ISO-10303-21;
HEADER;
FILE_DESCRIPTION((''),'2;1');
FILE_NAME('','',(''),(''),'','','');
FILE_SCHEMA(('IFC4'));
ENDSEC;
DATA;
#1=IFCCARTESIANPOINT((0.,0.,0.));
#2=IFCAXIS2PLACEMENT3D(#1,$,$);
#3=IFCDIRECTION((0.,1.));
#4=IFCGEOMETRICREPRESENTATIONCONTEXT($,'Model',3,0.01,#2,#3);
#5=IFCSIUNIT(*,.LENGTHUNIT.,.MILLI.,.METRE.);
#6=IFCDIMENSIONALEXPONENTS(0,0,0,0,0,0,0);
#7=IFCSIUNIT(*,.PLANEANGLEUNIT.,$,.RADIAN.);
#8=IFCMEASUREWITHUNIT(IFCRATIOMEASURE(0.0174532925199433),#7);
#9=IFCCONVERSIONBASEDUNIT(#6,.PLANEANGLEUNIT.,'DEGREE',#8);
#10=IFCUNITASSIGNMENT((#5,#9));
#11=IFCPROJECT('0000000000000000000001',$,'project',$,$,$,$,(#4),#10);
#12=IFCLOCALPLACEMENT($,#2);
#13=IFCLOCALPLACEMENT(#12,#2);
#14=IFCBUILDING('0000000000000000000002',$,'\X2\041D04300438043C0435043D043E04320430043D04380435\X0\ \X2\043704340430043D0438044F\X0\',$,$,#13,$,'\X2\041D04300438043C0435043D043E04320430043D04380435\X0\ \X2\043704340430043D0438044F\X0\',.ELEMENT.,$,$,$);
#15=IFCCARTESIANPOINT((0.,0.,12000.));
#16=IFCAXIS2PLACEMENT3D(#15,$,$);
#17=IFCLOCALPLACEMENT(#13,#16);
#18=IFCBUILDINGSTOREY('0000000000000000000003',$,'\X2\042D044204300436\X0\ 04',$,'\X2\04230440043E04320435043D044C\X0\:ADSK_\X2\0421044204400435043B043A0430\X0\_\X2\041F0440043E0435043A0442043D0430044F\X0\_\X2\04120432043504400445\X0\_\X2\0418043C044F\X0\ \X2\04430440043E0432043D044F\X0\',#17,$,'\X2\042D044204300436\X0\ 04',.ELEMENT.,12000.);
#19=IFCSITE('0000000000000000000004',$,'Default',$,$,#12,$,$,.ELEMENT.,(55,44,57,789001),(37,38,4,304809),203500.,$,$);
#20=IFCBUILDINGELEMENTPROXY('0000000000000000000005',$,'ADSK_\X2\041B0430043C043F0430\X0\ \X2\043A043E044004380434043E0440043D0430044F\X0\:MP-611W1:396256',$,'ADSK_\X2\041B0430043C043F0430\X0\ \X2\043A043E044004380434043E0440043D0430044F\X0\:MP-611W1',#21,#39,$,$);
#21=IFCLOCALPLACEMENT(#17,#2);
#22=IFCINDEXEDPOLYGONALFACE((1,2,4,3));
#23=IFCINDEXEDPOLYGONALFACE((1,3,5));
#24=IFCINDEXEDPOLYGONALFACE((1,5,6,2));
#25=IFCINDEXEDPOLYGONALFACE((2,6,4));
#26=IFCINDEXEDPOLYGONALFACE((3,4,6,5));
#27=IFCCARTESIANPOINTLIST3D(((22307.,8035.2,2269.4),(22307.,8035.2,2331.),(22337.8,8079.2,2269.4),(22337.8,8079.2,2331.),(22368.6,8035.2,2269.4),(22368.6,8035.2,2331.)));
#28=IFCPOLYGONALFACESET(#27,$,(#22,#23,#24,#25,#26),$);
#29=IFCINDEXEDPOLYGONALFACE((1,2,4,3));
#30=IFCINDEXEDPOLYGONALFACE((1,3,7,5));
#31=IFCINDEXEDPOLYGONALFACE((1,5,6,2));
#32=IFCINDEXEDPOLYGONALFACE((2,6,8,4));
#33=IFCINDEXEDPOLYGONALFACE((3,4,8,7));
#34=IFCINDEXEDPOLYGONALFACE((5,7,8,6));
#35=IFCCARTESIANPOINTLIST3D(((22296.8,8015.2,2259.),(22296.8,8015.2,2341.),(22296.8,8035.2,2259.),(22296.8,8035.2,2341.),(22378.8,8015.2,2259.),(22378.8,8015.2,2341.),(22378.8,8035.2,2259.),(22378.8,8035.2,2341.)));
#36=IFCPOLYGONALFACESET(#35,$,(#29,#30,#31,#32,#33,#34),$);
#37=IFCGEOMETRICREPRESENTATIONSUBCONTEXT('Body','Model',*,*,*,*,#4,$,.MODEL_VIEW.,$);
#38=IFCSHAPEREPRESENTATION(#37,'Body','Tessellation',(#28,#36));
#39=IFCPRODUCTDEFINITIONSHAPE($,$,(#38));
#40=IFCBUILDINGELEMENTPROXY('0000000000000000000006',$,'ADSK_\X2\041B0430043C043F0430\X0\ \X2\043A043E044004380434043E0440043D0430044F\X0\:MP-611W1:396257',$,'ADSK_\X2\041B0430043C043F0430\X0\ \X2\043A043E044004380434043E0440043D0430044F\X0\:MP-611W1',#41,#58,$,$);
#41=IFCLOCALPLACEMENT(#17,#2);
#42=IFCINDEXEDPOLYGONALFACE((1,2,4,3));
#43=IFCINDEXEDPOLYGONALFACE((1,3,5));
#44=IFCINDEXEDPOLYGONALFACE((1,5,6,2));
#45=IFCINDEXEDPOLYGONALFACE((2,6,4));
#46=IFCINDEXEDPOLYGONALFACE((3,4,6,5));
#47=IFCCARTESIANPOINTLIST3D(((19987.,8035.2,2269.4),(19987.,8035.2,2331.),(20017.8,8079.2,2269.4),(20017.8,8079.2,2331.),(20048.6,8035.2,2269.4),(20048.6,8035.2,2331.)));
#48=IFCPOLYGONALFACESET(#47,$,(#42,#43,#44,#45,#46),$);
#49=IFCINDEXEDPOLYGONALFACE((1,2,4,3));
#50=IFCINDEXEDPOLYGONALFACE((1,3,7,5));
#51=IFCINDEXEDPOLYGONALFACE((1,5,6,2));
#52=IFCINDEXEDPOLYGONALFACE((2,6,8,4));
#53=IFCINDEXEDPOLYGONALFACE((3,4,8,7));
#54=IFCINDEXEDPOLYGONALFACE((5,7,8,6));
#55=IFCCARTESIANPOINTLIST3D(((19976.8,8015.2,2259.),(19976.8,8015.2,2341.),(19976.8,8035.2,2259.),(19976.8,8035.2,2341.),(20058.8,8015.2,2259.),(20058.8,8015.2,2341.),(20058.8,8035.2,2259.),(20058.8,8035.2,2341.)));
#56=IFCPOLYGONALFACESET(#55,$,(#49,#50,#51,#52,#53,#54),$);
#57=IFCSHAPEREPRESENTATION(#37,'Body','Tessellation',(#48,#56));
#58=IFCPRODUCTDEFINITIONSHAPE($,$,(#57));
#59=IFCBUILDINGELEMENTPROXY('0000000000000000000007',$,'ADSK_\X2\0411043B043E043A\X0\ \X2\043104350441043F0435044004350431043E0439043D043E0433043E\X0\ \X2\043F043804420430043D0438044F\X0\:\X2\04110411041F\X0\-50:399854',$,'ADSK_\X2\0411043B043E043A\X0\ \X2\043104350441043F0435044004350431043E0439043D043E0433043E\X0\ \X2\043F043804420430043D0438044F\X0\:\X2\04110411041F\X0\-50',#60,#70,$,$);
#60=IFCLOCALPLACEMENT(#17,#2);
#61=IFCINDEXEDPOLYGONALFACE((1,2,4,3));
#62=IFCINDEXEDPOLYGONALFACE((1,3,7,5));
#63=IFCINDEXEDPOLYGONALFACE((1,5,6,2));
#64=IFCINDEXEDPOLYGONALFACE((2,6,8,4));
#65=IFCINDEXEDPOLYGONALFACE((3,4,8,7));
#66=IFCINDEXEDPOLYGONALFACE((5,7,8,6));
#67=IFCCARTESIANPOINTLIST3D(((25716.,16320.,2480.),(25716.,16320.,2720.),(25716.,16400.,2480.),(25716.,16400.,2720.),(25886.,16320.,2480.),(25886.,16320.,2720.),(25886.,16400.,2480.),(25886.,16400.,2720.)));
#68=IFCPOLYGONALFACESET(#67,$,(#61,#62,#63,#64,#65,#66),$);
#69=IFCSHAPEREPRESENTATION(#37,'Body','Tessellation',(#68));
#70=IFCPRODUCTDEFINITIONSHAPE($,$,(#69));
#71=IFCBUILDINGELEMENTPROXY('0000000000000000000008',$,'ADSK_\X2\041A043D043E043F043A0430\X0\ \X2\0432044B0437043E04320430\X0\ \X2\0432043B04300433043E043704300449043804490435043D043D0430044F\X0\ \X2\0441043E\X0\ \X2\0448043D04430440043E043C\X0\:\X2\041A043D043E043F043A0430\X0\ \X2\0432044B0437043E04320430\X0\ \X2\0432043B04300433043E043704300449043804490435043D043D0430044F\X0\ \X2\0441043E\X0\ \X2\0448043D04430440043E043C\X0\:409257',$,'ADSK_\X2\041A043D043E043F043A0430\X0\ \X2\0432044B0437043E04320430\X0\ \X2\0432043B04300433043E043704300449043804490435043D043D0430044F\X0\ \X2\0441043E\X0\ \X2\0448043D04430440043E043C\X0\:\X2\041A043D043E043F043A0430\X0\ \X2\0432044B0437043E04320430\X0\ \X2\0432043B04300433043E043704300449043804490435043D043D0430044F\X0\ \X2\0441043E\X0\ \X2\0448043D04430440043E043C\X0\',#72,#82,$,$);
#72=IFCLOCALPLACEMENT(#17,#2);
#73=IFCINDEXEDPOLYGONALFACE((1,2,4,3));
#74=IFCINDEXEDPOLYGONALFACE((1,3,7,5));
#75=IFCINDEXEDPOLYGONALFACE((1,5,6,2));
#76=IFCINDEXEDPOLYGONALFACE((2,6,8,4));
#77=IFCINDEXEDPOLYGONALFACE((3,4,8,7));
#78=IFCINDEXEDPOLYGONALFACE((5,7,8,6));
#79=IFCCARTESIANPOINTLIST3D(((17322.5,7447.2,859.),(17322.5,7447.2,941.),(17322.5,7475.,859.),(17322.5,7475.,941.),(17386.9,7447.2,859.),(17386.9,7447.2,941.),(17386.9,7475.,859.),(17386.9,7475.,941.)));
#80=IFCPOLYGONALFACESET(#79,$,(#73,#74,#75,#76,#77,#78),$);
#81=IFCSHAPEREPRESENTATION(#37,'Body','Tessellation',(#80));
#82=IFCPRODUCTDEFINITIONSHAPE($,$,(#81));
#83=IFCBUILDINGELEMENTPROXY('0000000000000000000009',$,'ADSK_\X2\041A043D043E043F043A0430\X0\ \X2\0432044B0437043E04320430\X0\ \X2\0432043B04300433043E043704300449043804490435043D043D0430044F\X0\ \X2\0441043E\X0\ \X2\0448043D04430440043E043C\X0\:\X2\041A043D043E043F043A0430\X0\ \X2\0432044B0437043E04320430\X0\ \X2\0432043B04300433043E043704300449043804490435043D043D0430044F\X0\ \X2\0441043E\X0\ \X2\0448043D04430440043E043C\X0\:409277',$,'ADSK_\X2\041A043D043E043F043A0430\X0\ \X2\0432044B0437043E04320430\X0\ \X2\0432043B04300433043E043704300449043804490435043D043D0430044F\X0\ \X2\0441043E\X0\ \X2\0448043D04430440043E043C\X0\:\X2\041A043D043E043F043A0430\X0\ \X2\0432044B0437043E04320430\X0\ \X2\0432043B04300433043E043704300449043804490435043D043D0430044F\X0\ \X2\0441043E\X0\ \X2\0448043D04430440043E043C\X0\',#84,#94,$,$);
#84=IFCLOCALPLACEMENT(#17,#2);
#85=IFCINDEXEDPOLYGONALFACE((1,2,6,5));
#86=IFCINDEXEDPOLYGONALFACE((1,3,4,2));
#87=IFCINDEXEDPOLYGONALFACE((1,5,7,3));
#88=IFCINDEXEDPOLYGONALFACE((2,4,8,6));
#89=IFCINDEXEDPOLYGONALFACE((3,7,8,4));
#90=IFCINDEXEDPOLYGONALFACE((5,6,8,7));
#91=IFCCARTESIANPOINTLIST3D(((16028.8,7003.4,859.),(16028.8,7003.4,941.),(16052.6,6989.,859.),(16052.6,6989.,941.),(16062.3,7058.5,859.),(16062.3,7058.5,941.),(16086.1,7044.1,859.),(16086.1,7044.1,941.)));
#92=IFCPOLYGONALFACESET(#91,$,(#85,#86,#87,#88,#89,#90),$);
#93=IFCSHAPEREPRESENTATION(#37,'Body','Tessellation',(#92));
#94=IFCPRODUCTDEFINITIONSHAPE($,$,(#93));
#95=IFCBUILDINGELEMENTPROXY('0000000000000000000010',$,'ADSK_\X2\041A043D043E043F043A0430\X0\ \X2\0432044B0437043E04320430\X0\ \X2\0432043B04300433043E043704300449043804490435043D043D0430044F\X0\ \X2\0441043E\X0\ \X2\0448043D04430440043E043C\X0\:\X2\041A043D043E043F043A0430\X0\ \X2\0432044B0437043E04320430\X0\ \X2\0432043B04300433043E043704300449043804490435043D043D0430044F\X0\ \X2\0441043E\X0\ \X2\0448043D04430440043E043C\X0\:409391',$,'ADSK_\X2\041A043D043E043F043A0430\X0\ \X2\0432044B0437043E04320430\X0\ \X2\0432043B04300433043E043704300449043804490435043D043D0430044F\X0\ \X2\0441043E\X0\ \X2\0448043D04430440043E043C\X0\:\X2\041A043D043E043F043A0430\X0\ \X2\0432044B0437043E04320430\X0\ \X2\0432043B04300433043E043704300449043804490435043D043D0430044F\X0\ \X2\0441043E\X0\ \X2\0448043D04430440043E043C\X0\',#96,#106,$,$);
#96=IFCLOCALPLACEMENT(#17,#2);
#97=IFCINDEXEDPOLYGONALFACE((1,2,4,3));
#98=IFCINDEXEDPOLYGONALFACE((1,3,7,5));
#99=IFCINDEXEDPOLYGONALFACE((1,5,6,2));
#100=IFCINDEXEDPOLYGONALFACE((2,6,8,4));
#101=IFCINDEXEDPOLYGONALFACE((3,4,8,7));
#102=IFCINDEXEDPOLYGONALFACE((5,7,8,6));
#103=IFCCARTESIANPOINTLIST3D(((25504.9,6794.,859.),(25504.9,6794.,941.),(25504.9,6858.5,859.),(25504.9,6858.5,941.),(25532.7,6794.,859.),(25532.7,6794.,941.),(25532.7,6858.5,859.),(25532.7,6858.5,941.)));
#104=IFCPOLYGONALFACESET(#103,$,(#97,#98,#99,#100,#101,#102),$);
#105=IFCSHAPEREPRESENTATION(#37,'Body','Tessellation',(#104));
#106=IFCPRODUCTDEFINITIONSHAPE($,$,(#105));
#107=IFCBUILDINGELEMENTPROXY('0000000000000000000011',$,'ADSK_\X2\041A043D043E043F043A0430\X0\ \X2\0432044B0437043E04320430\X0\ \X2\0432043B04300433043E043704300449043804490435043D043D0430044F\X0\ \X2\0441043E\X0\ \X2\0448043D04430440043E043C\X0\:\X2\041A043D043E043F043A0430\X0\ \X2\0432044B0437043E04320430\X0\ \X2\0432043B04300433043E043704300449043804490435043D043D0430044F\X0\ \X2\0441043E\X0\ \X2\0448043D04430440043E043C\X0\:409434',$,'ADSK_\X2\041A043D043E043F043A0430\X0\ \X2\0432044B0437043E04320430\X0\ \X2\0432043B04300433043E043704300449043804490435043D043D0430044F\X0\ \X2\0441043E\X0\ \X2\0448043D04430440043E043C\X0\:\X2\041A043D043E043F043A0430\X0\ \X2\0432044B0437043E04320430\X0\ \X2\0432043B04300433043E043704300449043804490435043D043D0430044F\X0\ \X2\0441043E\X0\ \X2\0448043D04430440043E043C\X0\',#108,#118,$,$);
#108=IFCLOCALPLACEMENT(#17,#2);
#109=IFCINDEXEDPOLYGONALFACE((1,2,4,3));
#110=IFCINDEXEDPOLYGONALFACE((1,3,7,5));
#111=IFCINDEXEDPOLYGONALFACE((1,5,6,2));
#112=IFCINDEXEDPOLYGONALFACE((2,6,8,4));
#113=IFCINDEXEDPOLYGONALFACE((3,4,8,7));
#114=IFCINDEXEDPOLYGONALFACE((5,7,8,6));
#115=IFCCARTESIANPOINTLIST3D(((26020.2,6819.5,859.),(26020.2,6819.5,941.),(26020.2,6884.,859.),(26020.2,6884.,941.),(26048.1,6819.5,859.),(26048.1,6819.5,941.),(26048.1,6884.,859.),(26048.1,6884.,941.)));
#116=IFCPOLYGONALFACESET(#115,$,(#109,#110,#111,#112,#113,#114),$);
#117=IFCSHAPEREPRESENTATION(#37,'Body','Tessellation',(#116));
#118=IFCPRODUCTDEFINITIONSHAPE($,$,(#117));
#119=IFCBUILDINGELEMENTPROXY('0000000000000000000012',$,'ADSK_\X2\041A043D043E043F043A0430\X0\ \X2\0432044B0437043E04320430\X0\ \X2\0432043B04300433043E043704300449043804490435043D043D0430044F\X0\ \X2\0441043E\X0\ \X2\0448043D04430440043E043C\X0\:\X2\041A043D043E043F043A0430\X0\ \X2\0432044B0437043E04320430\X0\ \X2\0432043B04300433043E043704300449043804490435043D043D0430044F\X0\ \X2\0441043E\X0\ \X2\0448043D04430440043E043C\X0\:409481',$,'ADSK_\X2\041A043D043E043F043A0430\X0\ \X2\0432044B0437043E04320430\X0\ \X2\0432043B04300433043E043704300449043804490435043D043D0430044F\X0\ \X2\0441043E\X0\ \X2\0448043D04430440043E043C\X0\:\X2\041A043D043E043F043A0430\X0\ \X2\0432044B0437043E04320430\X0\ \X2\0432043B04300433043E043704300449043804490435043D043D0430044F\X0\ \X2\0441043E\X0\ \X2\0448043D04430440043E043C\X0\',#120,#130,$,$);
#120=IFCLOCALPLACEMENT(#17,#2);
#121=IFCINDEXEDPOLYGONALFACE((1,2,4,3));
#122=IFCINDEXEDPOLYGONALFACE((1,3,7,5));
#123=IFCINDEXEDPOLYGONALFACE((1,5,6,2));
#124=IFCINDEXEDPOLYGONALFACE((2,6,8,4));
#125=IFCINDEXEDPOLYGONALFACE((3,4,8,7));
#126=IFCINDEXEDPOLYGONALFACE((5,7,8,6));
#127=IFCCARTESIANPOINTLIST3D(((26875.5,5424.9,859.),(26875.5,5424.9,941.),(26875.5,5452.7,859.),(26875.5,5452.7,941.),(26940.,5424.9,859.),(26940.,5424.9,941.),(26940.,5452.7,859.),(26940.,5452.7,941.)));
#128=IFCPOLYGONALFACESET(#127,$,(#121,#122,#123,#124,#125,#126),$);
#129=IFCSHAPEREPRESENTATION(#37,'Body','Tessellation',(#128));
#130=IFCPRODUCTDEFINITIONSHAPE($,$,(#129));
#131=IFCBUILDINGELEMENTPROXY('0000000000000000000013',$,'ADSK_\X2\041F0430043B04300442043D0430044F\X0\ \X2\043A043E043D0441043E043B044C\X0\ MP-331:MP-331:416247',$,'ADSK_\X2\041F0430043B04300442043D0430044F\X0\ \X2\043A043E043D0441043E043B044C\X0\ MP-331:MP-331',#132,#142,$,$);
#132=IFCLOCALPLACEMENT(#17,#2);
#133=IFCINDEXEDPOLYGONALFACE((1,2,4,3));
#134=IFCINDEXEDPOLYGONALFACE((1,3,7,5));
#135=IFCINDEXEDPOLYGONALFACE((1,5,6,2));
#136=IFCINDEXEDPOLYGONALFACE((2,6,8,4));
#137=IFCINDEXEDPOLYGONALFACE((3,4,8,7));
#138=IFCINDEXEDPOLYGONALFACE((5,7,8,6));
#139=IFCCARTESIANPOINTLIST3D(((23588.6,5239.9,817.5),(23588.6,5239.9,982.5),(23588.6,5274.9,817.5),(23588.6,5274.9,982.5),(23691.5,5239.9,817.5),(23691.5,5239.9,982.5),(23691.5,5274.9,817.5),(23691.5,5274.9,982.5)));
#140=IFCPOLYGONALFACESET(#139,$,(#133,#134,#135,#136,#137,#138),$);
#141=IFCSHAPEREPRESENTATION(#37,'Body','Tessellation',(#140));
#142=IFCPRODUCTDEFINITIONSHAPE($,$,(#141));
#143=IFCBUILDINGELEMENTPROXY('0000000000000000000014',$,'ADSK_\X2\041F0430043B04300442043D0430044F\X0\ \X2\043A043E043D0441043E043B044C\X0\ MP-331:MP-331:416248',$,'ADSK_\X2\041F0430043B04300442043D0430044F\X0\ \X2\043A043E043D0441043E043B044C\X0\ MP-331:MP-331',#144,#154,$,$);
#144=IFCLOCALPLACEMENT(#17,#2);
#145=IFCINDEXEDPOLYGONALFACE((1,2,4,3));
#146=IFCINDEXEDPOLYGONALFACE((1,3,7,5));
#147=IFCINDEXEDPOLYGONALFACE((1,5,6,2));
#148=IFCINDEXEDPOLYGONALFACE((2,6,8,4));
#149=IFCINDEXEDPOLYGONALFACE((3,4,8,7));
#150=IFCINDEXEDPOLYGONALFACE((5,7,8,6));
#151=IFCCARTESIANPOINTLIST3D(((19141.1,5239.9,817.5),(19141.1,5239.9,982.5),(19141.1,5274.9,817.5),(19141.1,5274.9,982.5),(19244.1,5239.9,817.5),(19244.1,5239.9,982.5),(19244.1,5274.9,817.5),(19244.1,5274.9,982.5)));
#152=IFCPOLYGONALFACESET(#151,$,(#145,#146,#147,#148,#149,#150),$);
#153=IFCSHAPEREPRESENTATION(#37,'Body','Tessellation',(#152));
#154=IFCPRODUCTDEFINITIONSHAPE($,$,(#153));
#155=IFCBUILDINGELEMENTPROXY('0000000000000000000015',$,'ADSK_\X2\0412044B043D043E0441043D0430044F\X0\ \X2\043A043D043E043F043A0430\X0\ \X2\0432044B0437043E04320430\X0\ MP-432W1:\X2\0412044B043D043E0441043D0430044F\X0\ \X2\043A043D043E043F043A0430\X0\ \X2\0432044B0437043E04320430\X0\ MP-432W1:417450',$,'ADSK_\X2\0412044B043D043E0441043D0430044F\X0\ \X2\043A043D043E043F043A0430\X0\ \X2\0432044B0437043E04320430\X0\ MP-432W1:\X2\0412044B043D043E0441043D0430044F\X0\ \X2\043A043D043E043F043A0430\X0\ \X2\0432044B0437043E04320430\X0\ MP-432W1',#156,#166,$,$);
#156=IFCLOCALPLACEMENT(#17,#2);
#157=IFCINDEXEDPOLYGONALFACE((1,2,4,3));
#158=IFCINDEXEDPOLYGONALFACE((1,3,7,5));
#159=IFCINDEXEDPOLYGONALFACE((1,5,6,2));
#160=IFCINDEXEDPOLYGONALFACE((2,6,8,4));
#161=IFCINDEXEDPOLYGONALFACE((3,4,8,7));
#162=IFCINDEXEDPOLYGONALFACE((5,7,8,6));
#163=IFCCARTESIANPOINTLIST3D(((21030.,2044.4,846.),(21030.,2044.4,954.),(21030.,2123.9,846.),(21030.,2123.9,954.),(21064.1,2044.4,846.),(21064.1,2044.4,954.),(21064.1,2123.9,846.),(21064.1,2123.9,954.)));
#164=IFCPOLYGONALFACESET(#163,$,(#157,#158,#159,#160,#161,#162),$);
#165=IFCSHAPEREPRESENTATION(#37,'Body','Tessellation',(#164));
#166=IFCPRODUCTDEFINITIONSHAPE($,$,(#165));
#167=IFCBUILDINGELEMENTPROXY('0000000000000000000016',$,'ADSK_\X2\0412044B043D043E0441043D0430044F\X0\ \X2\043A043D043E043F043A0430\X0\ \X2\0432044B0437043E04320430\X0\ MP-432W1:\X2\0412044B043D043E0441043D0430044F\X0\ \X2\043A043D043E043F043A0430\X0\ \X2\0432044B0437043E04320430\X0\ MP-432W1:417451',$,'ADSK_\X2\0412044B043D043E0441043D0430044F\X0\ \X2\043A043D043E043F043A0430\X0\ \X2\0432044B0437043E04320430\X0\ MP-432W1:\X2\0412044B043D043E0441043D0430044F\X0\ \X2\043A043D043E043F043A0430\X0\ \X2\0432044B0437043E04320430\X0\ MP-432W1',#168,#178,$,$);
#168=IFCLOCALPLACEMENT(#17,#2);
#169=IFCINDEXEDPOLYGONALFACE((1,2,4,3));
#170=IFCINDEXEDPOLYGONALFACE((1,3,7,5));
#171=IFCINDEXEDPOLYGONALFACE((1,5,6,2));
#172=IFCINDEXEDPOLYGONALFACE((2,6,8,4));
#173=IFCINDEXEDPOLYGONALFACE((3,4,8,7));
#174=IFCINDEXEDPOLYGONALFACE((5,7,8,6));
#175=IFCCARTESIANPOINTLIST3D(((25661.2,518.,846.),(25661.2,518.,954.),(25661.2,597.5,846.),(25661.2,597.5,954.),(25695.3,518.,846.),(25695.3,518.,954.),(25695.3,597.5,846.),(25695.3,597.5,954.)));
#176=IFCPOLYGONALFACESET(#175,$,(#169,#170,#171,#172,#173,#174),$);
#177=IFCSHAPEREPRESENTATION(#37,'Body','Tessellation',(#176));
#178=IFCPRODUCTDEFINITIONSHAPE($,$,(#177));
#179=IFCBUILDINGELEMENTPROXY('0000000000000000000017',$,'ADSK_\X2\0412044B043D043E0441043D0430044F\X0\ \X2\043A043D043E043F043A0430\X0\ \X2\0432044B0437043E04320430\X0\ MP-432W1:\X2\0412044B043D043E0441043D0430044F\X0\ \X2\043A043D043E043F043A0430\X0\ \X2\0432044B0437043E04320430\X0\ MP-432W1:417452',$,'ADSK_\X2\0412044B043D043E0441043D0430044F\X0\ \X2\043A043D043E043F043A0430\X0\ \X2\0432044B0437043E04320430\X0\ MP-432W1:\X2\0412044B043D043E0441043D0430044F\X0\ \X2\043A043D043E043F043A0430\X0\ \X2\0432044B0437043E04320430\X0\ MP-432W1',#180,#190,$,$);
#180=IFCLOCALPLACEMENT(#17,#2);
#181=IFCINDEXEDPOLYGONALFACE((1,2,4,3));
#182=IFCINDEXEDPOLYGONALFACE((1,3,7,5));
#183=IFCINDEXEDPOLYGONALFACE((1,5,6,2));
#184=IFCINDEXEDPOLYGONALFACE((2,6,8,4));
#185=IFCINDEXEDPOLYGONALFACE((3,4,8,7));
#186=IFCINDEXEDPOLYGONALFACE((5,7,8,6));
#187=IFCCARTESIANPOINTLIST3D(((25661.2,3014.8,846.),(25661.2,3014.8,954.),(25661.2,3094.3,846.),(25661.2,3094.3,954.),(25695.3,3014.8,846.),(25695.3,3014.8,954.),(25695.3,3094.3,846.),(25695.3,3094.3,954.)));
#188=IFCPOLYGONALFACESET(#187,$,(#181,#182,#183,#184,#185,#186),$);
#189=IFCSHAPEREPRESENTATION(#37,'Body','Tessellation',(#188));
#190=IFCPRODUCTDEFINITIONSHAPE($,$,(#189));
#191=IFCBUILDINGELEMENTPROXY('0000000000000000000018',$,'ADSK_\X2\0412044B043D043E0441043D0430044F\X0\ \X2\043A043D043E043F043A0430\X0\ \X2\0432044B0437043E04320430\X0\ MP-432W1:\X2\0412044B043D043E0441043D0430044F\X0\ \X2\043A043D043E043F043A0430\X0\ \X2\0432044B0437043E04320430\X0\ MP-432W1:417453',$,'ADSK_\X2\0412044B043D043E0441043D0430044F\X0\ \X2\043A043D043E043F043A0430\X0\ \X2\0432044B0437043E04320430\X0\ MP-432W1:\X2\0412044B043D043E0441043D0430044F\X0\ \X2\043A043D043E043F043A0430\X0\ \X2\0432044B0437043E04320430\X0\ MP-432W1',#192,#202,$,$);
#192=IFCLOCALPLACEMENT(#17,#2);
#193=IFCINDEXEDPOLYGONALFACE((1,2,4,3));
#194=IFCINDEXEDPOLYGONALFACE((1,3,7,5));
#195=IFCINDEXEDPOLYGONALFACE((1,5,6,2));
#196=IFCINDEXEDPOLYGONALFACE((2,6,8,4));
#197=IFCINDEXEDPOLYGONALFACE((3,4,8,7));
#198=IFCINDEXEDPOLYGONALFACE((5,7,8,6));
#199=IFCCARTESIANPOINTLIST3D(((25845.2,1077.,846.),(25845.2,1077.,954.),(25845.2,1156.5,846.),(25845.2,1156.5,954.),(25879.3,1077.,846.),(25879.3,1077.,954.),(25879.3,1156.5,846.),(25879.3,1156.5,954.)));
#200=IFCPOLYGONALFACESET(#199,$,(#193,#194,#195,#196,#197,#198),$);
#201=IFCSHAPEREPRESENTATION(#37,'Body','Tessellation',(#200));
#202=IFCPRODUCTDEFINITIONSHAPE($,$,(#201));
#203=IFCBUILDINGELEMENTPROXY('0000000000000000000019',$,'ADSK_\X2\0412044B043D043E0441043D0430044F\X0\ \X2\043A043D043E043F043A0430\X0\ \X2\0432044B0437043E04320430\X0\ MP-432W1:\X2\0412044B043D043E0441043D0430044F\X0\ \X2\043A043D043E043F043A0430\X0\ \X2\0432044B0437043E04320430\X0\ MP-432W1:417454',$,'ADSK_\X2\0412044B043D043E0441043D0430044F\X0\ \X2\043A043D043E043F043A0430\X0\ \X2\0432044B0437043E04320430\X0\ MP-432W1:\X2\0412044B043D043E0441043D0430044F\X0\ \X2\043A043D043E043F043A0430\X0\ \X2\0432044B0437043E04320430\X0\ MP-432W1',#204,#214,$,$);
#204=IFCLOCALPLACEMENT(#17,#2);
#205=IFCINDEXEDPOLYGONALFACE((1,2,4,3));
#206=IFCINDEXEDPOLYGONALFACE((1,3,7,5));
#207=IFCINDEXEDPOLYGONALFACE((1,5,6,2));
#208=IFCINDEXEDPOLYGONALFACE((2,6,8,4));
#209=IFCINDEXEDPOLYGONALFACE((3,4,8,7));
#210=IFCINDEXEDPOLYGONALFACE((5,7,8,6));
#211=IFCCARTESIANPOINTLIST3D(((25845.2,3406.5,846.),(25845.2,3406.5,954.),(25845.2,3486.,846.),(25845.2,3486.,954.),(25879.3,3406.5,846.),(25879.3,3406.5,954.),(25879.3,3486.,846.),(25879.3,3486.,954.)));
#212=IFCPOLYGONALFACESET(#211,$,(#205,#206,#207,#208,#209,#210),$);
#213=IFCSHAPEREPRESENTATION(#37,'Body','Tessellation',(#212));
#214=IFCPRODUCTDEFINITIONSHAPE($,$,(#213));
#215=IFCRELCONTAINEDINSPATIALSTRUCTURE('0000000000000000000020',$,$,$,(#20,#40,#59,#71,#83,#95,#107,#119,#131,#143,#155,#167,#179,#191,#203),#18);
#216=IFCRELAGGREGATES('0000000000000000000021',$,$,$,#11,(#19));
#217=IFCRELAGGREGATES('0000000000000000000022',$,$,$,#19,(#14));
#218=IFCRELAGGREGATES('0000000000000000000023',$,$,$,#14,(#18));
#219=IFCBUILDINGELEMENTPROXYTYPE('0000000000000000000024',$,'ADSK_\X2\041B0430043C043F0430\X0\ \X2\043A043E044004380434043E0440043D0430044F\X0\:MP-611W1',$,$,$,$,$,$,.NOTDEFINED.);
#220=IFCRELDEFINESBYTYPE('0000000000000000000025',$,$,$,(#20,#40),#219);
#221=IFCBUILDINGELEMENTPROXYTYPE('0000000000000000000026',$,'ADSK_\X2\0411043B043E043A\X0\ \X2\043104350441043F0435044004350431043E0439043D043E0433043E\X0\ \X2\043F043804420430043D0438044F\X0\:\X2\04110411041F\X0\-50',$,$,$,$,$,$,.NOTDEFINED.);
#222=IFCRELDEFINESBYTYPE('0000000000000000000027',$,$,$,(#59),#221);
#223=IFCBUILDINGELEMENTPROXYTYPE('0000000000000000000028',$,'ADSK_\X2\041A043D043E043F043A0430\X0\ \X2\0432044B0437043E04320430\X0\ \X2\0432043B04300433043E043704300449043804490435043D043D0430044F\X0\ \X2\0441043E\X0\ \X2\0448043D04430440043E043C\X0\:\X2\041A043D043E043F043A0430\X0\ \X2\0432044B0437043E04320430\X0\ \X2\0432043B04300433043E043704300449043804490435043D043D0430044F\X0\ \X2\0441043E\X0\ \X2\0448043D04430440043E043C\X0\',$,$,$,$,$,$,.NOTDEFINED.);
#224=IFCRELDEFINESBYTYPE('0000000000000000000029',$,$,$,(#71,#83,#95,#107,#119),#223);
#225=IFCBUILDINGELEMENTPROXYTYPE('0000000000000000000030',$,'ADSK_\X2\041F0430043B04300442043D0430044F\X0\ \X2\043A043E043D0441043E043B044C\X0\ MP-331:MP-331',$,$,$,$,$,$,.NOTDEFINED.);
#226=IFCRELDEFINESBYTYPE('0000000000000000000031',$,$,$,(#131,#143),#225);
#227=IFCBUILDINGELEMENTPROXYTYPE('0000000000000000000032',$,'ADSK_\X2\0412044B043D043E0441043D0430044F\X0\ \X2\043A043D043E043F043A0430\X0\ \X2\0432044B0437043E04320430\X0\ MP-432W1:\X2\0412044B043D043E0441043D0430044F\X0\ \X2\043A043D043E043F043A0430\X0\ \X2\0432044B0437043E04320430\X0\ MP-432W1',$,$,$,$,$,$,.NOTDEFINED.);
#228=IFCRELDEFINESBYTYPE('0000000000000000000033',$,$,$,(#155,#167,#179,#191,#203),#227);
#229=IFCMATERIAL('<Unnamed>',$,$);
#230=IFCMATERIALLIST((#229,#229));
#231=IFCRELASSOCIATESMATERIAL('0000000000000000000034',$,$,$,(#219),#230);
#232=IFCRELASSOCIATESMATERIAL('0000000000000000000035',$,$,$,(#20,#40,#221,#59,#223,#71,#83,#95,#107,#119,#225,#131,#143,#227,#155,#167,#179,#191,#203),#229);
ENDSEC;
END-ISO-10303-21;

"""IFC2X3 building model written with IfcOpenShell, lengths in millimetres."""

from ifc_helpers import new_model, entity, si_unit, converted_unit, direction, frame, origin, origin_2d_with_axis, place, context, subcontext, project, spatial, polyline, rectangle, outline, extrude, source, transform, mapped, material, material_list, type_object, type_shapes, element, save


model = new_model("IFC2X3")

# Units and contexts
model_context = context("Model", 3, precision=0.01, world=origin(), true_north=direction((0.0, 1.0)))
body_context = subcontext(model_context, "Body", "Model", "MODEL_VIEW")
ifc_project = project(units=[si_unit("LENGTHUNIT", "METRE", prefix="MILLI"), converted_unit("PLANEANGLEUNIT", "DEGREE", entity("IfcRatioMeasure", 0.0174532925199433), si_unit("PLANEANGLEUNIT", "RADIAN"), dimensions=[0, 0, 0, 0, 0, 0, 0])], contexts=[model_context])

# Site, building, storey
site_placement = place(None, origin())
site = spatial("IfcSite", under=ifc_project, at=site_placement, Name="Default", CompositionType="ELEMENT", RefLatitude=(55, 44, 57, 789001), RefLongitude=(37, 38, 4, 304809), RefElevation=203500.0)
building_placement = place(site_placement, origin())
building = spatial("IfcBuilding", under=site, at=building_placement, Name="Наименование здания", LongName="Наименование здания", CompositionType="ELEMENT")
storey_placement = place(building_placement, frame((0.0, 0.0, 12000.0)))
storey = spatial("IfcBuildingStorey", under=building, at=storey_placement, Name="Этаж 04", ObjectType="Уровень:ADSK_Стрелка_Проектная_Вверх_Имя уровня", LongName="Этаж 04", CompositionType="ELEMENT", Elevation=12000.0)

# Building element proxies
ifc_material_1 = material(Name="<Unnamed>")
ifc_material_list_1 = material_list([ifc_material_1, ifc_material_1])
building_element_proxy_type_1 = type_object("IfcBuildingElementProxyType", Name="ADSK_Лампа коридорная:MP-611W1", PredefinedType="NOTDEFINED", material=ifc_material_list_1)
shared_shape_1 = source(origin(), body_context, "Body", "SweptSolid", [
    extrude(outline(polyline([(-30.8, -14.7), (30.8, -14.7), (0.0, 29.3), (-30.8, -14.7)])), frame((0.0, -2.7, -30.6), z_axis=(0.0, 0.0, 1.0), x_axis=(-1.0, 0.0, 0.0)), (0.0, 0.0, 1.0), 61.6),
    extrude(rectangle(XDim=82.0, YDim=20.0, at=origin_2d_with_axis()), frame((0.0, 22.0, -41.0), z_axis=(0.0, 0.0, 1.0), x_axis=(-1.0, 0.0, 0.0)), (0.0, 0.0, 1.0), 82.0),
])
type_shapes(building_element_proxy_type_1, [shared_shape_1])
for number, where, z_axis, x_axis, name in (
    (1, (22337.8, 8047.1, 2300.0), (0.0, 0.0, 1.0), (-1.0, 0.0, 0.0), "ADSK_Лампа коридорная:MP-611W1:396256"),
    (2, (20017.8, 8047.1, 2300.0), (0.0, 0.0, 1.0), (-1.0, 0.0, 0.0), "ADSK_Лампа коридорная:MP-611W1:396257"),
):
    element("IfcBuildingElementProxy", number, at=place(storey_placement, frame(where, z_axis=z_axis, x_axis=x_axis)), inside=storey, type_object=building_element_proxy_type_1, material=ifc_material_1, Name=name, ObjectType="ADSK_Лампа коридорная:MP-611W1", context=body_context, shape_type="MappedRepresentation", body=[
        mapped(shared_shape_1, transform((0.0, 0.0, 0.0), scale=1.0)),
    ])
building_element_proxy_type_2 = type_object("IfcBuildingElementProxyType", Name="ADSK_Блок бесперебойного питания:ББП-50", PredefinedType="NOTDEFINED", material=ifc_material_1)
shared_shape_2 = source(origin(), body_context, "Body", "SweptSolid", [
    extrude(rectangle(XDim=170.0, YDim=80.0, at=origin_2d_with_axis()), frame((0.0, -8.0, -120.0), z_axis=(0.0, 0.0, 1.0), x_axis=(-1.0, 0.0, 0.0)), (0.0, 0.0, 1.0), 240.0),
])
type_shapes(building_element_proxy_type_2, [shared_shape_2])
proxy_1_placement = place(storey_placement, frame((25801.0, 16368.0, 2600.0)))
element("IfcBuildingElementProxy", 3, at=proxy_1_placement, inside=storey, type_object=building_element_proxy_type_2, material=ifc_material_1, Name="ADSK_Блок бесперебойного питания:ББП-50:399854", ObjectType="ADSK_Блок бесперебойного питания:ББП-50", context=body_context, shape_type="MappedRepresentation", body=[
    mapped(shared_shape_2, transform((0.0, 0.0, 0.0), scale=1.0)),
])
building_element_proxy_type_3 = type_object("IfcBuildingElementProxyType", Name="ADSK_Кнопка вызова влагозащищенная со шнуром:Кнопка вызова влагозащищенная со шнуром", PredefinedType="NOTDEFINED", material=ifc_material_1)
shared_shape_3 = source(origin(), body_context, "Body", "SweptSolid", [
    extrude(rectangle(XDim=64.5, YDim=27.8, at=origin_2d_with_axis()), frame((32.2, 13.9, 0.0), z_axis=(0.0, 0.0, 1.0), x_axis=(-1.0, 0.0, 0.0)), (0.0, 0.0, 1.0), 82.0),
])
type_shapes(building_element_proxy_type_3, [shared_shape_3])
proxy_2_placement = place(storey_placement, frame((17322.5, 7447.2, 859.0)))
element("IfcBuildingElementProxy", 4, at=proxy_2_placement, inside=storey, type_object=building_element_proxy_type_3, material=ifc_material_1, Name="ADSK_Кнопка вызова влагозащищенная со шнуром:Кнопка вызова влагозащищенная со шнуром:409257", ObjectType="ADSK_Кнопка вызова влагозащищенная со шнуром:Кнопка вызова влагозащищенная со шнуром", context=body_context, shape_type="MappedRepresentation", body=[
    mapped(shared_shape_3, transform((0.0, 0.0, 0.0), scale=1.0)),
])
for number, where, z_axis, x_axis, name in (
    (5, (16052.6, 6989.0, 859.0), (0.0, 0.0, 1.0), (0.519535, 0.854449, 0.0), "ADSK_Кнопка вызова влагозащищенная со шнуром:Кнопка вызова влагозащищенная со шнуром:409277"),
    (6, (25504.9, 6858.5, 859.0), (0.0, 0.0, 1.0), (0.0, -1.0, 0.0), "ADSK_Кнопка вызова влагозащищенная со шнуром:Кнопка вызова влагозащищенная со шнуром:409391"),
    (7, (26048.1, 6819.5, 859.0), (0.0, 0.0, 1.0), (0.0, 1.0, 0.0), "ADSK_Кнопка вызова влагозащищенная со шнуром:Кнопка вызова влагозащищенная со шнуром:409434"),
    (8, (26940.0, 5452.8, 859.0), (0.0, 0.0, 1.0), (-1.0, 0.0, 0.0), "ADSK_Кнопка вызова влагозащищенная со шнуром:Кнопка вызова влагозащищенная со шнуром:409481"),
):
    element("IfcBuildingElementProxy", number, at=place(storey_placement, frame(where, z_axis=z_axis, x_axis=x_axis)), inside=storey, type_object=building_element_proxy_type_3, material=ifc_material_1, Name=name, ObjectType="ADSK_Кнопка вызова влагозащищенная со шнуром:Кнопка вызова влагозащищенная со шнуром", context=body_context, shape_type="MappedRepresentation", body=[
        mapped(shared_shape_3, transform((0.0, 0.0, 0.0), scale=1.0)),
    ])
building_element_proxy_type_4 = type_object("IfcBuildingElementProxyType", Name="ADSK_Палатная консоль MP-331:MP-331", PredefinedType="NOTDEFINED", material=ifc_material_1)
shared_shape_4 = source(origin(), body_context, "Body", "SweptSolid", [
    extrude(rectangle(XDim=103.0, YDim=35.0, at=origin_2d_with_axis()), frame((0.0, 14.5, -82.5), z_axis=(0.0, 0.0, 1.0), x_axis=(-1.0, 0.0, 0.0)), (0.0, 0.0, 1.0), 165.0),
])
type_shapes(building_element_proxy_type_4, [shared_shape_4])
for number, where, name in (
    (9, (23640.0, 5242.9, 900.0), "ADSK_Палатная консоль MP-331:MP-331:416247"),
    (10, (19192.6, 5242.9, 900.0), "ADSK_Палатная консоль MP-331:MP-331:416248"),
):
    element("IfcBuildingElementProxy", number, at=place(storey_placement, frame(where)), inside=storey, type_object=building_element_proxy_type_4, material=ifc_material_1, Name=name, ObjectType="ADSK_Палатная консоль MP-331:MP-331", context=body_context, shape_type="MappedRepresentation", body=[
        mapped(shared_shape_4, transform((0.0, 0.0, 0.0), scale=1.0)),
    ])
building_element_proxy_type_5 = type_object("IfcBuildingElementProxyType", Name="ADSK_Выносная кнопка вызова MP-432W1:Выносная кнопка вызова MP-432W1", PredefinedType="NOTDEFINED", material=ifc_material_1)
shared_shape_5 = source(origin(), body_context, "Body", "SweptSolid", [
    extrude(rectangle(XDim=79.5, YDim=34.1, at=origin_2d_with_axis()), frame((0.0, 15.0, -54.0), z_axis=(0.0, 0.0, 1.0), x_axis=(-1.0, 0.0, 0.0)), (0.0, 0.0, 1.0), 108.0),
])
type_shapes(building_element_proxy_type_5, [shared_shape_5])
for number, where, z_axis, x_axis, name in (
    (11, (21032.1, 2084.2, 900.0), (0.0, 0.0, 1.0), (0.0, -1.0, 0.0), "ADSK_Выносная кнопка вызова MP-432W1:Выносная кнопка вызова MP-432W1:417450"),
    (12, (25663.2, 557.8, 900.0), (0.0, 0.0, 1.0), (0.0, -1.0, 0.0), "ADSK_Выносная кнопка вызова MP-432W1:Выносная кнопка вызова MP-432W1:417451"),
    (13, (25663.2, 3054.5, 900.0), (0.0, 0.0, 1.0), (0.0, -1.0, 0.0), "ADSK_Выносная кнопка вызова MP-432W1:Выносная кнопка вызова MP-432W1:417452"),
    (14, (25877.2, 1116.7, 900.0), (0.0, 0.0, 1.0), (0.0, 1.0, 0.0), "ADSK_Выносная кнопка вызова MP-432W1:Выносная кнопка вызова MP-432W1:417453"),
    (15, (25877.2, 3446.2, 900.0), (0.0, 0.0, 1.0), (0.0, 1.0, 0.0), "ADSK_Выносная кнопка вызова MP-432W1:Выносная кнопка вызова MP-432W1:417454"),
):
    element("IfcBuildingElementProxy", number, at=place(storey_placement, frame(where, z_axis=z_axis, x_axis=x_axis)), inside=storey, type_object=building_element_proxy_type_5, material=ifc_material_1, Name=name, ObjectType="ADSK_Выносная кнопка вызова MP-432W1:Выносная кнопка вызова MP-432W1", context=body_context, shape_type="MappedRepresentation", body=[
        mapped(shared_shape_5, transform((0.0, 0.0, 0.0), scale=1.0)),
    ])

save(model, "model.ifc")
